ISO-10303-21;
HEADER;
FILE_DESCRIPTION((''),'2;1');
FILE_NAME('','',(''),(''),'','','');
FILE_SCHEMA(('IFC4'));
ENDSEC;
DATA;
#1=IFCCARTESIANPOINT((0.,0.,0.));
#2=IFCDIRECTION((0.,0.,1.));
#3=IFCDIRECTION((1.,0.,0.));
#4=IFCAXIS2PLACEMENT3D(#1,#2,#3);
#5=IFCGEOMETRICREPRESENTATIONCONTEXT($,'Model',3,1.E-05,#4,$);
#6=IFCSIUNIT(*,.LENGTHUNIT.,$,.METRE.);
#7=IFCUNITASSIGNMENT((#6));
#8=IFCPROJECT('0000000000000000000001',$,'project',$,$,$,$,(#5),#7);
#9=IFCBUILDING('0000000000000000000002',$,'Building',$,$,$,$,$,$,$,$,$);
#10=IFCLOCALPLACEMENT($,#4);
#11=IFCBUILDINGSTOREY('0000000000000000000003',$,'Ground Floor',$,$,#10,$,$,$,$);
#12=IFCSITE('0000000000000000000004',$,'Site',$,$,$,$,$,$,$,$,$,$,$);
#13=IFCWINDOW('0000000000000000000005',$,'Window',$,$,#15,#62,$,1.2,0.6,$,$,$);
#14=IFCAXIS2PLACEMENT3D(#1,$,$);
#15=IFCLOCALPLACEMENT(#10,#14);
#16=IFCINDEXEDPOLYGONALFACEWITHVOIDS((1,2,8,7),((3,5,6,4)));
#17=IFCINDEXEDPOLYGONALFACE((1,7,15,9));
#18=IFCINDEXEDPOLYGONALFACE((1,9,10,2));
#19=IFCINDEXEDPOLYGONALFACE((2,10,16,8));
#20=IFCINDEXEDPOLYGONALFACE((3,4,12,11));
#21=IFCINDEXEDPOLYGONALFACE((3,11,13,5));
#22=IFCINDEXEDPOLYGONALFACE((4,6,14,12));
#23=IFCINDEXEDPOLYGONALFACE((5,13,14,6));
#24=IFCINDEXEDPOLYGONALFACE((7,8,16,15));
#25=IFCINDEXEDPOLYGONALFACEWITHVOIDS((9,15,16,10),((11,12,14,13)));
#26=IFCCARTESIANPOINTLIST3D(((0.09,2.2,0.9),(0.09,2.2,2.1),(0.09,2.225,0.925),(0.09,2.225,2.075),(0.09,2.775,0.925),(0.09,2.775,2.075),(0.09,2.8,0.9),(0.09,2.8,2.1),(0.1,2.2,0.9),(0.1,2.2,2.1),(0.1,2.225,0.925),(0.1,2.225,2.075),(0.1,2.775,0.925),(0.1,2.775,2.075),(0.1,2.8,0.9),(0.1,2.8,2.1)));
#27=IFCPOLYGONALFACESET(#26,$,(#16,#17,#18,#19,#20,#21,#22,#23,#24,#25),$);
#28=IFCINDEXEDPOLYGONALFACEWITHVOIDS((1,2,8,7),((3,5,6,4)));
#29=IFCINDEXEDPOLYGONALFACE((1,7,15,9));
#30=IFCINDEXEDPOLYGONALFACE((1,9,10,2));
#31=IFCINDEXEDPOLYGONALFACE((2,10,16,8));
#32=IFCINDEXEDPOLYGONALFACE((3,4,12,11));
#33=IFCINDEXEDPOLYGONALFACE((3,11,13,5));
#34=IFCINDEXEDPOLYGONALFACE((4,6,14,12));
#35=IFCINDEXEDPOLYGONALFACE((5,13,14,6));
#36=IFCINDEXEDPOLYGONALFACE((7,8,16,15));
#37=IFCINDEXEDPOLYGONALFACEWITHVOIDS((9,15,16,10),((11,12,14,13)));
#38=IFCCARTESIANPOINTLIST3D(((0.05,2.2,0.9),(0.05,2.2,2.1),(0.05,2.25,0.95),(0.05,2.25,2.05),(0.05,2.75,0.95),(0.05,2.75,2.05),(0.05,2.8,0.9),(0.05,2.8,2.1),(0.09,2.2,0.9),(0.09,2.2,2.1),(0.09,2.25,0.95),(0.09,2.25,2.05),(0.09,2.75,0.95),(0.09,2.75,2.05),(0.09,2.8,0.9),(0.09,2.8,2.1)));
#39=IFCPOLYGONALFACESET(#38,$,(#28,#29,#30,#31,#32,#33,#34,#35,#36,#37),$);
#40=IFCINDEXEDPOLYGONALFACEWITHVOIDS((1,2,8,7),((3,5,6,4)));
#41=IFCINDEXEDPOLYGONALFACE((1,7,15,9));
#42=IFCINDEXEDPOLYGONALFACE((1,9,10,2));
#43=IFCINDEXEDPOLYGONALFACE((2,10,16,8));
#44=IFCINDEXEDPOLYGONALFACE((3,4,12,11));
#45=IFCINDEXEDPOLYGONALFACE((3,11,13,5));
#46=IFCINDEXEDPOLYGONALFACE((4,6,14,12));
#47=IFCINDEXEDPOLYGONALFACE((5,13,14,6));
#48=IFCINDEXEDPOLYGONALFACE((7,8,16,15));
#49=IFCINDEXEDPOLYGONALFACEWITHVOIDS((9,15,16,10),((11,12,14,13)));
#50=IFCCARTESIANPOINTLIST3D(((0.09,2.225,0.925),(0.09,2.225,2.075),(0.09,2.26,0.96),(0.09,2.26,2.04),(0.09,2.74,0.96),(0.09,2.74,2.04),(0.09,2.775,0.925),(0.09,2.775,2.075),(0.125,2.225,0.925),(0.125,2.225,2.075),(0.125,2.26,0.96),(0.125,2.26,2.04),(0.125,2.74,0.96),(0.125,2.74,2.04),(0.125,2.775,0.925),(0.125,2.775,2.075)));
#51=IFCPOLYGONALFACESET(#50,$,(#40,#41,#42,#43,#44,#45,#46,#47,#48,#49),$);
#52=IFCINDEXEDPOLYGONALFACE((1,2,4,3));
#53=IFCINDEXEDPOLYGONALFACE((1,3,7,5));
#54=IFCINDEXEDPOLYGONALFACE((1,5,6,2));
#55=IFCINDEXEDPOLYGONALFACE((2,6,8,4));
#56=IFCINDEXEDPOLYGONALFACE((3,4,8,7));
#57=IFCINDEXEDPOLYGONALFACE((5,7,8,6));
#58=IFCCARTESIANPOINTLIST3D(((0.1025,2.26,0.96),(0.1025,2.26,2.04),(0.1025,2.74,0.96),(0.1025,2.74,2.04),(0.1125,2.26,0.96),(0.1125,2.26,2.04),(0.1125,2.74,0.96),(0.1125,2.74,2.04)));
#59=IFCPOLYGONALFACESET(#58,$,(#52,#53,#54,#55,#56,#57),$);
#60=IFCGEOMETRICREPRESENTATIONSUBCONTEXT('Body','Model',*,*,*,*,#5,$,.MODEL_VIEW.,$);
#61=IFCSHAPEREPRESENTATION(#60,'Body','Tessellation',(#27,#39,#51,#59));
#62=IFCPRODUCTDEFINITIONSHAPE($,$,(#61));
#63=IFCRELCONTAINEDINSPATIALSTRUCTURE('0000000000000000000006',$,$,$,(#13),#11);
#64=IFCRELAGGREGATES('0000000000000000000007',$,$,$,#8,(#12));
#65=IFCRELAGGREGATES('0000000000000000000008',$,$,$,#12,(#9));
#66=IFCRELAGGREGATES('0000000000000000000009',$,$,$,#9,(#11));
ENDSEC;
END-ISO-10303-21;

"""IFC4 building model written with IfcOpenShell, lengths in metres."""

from ifc_helpers import new_model, si_unit, frame, origin_with_axes, place, context, subcontext, project, spatial, line, indexed_curve, outline, extrude, element, save


model = new_model("IFC4")

# Units and contexts
model_context = context("Model", 3, precision=1e-05, world=origin_with_axes())
body_context = subcontext(model_context, "Body", "Model", "MODEL_VIEW")
ifc_project = project(units=[si_unit("LENGTHUNIT", "METRE")], contexts=[model_context])

# Site, building, storey
site = spatial("IfcSite", under=ifc_project, Name="Site")
building = spatial("IfcBuilding", under=site, Name="Building")
storey_placement = place(None, origin_with_axes())
storey = spatial("IfcBuildingStorey", under=building, at=storey_placement, Name="Ground Floor")

# Window
for number, where, z_axis, x_axis, name in (
    (1, (0.0, 2.8, 0.9), (0.0, 0.0, 1.0), (0.0, -1.0, 0.0), "Window"),
):
    element("IfcWindow", number, at=place(storey_placement, frame(where, z_axis=z_axis, x_axis=x_axis)), inside=storey, Name=name, OverallHeight=1.2, OverallWidth=0.6, context=body_context, shape_type="SweptSolid", body=[
        extrude(outline(indexed_curve([(0.0, 0.0), (0.6, 0.0), (0.6, 1.2), (0.0, 1.2)], segments=[line(1, 2, 3, 4, 1)]), holes=[indexed_curve([(0.025, 0.025), (0.575, 0.025), (0.575, 1.175), (0.025, 1.175)], segments=[line(1, 2, 3, 4, 1)])]), frame((0.0, 0.09, 0.0), z_axis=(0.0, -1.0, 0.0), x_axis=(1.0, 0.0, 0.0)), (0.0, 0.0, -1.0), 0.01),
        extrude(outline(indexed_curve([(0.0, 0.0), (0.6, 0.0), (0.6, 1.2), (0.0, 1.2)], segments=[line(1, 2, 3, 4, 1)]), holes=[indexed_curve([(0.05, 0.05), (0.55, 0.05), (0.55, 1.15), (0.05, 1.15)], segments=[line(1, 2, 3, 4, 1)])]), frame((0.0, 0.05, 0.0), z_axis=(0.0, -1.0, 0.0), x_axis=(1.0, 0.0, 0.0)), (0.0, 0.0, -1.0), 0.04),
        extrude(outline(indexed_curve([(0.0, 0.0), (0.55, 0.0), (0.55, 1.15), (0.0, 1.15)], segments=[line(1, 2, 3, 4, 1)]), holes=[indexed_curve([(0.035, 0.035), (0.515, 0.035), (0.515, 1.115), (0.035, 1.115)], segments=[line(1, 2, 3, 4, 1)])]), frame((0.025, 0.09, 0.025), z_axis=(0.0, -1.0, 0.0), x_axis=(1.0, 0.0, 0.0)), (0.0, 0.0, -1.0), 0.035),
        extrude(outline(indexed_curve([(0.035, 0.035), (0.515, 0.035), (0.515, 1.115), (0.035, 1.115)], segments=[line(1, 2, 3, 4, 1)])), frame((0.025, 0.1025, 0.025), z_axis=(0.0, -1.0, 0.0), x_axis=(1.0, 0.0, 0.0)), (0.0, 0.0, -1.0), 0.01),
    ])

save(model, "model.ifc")
